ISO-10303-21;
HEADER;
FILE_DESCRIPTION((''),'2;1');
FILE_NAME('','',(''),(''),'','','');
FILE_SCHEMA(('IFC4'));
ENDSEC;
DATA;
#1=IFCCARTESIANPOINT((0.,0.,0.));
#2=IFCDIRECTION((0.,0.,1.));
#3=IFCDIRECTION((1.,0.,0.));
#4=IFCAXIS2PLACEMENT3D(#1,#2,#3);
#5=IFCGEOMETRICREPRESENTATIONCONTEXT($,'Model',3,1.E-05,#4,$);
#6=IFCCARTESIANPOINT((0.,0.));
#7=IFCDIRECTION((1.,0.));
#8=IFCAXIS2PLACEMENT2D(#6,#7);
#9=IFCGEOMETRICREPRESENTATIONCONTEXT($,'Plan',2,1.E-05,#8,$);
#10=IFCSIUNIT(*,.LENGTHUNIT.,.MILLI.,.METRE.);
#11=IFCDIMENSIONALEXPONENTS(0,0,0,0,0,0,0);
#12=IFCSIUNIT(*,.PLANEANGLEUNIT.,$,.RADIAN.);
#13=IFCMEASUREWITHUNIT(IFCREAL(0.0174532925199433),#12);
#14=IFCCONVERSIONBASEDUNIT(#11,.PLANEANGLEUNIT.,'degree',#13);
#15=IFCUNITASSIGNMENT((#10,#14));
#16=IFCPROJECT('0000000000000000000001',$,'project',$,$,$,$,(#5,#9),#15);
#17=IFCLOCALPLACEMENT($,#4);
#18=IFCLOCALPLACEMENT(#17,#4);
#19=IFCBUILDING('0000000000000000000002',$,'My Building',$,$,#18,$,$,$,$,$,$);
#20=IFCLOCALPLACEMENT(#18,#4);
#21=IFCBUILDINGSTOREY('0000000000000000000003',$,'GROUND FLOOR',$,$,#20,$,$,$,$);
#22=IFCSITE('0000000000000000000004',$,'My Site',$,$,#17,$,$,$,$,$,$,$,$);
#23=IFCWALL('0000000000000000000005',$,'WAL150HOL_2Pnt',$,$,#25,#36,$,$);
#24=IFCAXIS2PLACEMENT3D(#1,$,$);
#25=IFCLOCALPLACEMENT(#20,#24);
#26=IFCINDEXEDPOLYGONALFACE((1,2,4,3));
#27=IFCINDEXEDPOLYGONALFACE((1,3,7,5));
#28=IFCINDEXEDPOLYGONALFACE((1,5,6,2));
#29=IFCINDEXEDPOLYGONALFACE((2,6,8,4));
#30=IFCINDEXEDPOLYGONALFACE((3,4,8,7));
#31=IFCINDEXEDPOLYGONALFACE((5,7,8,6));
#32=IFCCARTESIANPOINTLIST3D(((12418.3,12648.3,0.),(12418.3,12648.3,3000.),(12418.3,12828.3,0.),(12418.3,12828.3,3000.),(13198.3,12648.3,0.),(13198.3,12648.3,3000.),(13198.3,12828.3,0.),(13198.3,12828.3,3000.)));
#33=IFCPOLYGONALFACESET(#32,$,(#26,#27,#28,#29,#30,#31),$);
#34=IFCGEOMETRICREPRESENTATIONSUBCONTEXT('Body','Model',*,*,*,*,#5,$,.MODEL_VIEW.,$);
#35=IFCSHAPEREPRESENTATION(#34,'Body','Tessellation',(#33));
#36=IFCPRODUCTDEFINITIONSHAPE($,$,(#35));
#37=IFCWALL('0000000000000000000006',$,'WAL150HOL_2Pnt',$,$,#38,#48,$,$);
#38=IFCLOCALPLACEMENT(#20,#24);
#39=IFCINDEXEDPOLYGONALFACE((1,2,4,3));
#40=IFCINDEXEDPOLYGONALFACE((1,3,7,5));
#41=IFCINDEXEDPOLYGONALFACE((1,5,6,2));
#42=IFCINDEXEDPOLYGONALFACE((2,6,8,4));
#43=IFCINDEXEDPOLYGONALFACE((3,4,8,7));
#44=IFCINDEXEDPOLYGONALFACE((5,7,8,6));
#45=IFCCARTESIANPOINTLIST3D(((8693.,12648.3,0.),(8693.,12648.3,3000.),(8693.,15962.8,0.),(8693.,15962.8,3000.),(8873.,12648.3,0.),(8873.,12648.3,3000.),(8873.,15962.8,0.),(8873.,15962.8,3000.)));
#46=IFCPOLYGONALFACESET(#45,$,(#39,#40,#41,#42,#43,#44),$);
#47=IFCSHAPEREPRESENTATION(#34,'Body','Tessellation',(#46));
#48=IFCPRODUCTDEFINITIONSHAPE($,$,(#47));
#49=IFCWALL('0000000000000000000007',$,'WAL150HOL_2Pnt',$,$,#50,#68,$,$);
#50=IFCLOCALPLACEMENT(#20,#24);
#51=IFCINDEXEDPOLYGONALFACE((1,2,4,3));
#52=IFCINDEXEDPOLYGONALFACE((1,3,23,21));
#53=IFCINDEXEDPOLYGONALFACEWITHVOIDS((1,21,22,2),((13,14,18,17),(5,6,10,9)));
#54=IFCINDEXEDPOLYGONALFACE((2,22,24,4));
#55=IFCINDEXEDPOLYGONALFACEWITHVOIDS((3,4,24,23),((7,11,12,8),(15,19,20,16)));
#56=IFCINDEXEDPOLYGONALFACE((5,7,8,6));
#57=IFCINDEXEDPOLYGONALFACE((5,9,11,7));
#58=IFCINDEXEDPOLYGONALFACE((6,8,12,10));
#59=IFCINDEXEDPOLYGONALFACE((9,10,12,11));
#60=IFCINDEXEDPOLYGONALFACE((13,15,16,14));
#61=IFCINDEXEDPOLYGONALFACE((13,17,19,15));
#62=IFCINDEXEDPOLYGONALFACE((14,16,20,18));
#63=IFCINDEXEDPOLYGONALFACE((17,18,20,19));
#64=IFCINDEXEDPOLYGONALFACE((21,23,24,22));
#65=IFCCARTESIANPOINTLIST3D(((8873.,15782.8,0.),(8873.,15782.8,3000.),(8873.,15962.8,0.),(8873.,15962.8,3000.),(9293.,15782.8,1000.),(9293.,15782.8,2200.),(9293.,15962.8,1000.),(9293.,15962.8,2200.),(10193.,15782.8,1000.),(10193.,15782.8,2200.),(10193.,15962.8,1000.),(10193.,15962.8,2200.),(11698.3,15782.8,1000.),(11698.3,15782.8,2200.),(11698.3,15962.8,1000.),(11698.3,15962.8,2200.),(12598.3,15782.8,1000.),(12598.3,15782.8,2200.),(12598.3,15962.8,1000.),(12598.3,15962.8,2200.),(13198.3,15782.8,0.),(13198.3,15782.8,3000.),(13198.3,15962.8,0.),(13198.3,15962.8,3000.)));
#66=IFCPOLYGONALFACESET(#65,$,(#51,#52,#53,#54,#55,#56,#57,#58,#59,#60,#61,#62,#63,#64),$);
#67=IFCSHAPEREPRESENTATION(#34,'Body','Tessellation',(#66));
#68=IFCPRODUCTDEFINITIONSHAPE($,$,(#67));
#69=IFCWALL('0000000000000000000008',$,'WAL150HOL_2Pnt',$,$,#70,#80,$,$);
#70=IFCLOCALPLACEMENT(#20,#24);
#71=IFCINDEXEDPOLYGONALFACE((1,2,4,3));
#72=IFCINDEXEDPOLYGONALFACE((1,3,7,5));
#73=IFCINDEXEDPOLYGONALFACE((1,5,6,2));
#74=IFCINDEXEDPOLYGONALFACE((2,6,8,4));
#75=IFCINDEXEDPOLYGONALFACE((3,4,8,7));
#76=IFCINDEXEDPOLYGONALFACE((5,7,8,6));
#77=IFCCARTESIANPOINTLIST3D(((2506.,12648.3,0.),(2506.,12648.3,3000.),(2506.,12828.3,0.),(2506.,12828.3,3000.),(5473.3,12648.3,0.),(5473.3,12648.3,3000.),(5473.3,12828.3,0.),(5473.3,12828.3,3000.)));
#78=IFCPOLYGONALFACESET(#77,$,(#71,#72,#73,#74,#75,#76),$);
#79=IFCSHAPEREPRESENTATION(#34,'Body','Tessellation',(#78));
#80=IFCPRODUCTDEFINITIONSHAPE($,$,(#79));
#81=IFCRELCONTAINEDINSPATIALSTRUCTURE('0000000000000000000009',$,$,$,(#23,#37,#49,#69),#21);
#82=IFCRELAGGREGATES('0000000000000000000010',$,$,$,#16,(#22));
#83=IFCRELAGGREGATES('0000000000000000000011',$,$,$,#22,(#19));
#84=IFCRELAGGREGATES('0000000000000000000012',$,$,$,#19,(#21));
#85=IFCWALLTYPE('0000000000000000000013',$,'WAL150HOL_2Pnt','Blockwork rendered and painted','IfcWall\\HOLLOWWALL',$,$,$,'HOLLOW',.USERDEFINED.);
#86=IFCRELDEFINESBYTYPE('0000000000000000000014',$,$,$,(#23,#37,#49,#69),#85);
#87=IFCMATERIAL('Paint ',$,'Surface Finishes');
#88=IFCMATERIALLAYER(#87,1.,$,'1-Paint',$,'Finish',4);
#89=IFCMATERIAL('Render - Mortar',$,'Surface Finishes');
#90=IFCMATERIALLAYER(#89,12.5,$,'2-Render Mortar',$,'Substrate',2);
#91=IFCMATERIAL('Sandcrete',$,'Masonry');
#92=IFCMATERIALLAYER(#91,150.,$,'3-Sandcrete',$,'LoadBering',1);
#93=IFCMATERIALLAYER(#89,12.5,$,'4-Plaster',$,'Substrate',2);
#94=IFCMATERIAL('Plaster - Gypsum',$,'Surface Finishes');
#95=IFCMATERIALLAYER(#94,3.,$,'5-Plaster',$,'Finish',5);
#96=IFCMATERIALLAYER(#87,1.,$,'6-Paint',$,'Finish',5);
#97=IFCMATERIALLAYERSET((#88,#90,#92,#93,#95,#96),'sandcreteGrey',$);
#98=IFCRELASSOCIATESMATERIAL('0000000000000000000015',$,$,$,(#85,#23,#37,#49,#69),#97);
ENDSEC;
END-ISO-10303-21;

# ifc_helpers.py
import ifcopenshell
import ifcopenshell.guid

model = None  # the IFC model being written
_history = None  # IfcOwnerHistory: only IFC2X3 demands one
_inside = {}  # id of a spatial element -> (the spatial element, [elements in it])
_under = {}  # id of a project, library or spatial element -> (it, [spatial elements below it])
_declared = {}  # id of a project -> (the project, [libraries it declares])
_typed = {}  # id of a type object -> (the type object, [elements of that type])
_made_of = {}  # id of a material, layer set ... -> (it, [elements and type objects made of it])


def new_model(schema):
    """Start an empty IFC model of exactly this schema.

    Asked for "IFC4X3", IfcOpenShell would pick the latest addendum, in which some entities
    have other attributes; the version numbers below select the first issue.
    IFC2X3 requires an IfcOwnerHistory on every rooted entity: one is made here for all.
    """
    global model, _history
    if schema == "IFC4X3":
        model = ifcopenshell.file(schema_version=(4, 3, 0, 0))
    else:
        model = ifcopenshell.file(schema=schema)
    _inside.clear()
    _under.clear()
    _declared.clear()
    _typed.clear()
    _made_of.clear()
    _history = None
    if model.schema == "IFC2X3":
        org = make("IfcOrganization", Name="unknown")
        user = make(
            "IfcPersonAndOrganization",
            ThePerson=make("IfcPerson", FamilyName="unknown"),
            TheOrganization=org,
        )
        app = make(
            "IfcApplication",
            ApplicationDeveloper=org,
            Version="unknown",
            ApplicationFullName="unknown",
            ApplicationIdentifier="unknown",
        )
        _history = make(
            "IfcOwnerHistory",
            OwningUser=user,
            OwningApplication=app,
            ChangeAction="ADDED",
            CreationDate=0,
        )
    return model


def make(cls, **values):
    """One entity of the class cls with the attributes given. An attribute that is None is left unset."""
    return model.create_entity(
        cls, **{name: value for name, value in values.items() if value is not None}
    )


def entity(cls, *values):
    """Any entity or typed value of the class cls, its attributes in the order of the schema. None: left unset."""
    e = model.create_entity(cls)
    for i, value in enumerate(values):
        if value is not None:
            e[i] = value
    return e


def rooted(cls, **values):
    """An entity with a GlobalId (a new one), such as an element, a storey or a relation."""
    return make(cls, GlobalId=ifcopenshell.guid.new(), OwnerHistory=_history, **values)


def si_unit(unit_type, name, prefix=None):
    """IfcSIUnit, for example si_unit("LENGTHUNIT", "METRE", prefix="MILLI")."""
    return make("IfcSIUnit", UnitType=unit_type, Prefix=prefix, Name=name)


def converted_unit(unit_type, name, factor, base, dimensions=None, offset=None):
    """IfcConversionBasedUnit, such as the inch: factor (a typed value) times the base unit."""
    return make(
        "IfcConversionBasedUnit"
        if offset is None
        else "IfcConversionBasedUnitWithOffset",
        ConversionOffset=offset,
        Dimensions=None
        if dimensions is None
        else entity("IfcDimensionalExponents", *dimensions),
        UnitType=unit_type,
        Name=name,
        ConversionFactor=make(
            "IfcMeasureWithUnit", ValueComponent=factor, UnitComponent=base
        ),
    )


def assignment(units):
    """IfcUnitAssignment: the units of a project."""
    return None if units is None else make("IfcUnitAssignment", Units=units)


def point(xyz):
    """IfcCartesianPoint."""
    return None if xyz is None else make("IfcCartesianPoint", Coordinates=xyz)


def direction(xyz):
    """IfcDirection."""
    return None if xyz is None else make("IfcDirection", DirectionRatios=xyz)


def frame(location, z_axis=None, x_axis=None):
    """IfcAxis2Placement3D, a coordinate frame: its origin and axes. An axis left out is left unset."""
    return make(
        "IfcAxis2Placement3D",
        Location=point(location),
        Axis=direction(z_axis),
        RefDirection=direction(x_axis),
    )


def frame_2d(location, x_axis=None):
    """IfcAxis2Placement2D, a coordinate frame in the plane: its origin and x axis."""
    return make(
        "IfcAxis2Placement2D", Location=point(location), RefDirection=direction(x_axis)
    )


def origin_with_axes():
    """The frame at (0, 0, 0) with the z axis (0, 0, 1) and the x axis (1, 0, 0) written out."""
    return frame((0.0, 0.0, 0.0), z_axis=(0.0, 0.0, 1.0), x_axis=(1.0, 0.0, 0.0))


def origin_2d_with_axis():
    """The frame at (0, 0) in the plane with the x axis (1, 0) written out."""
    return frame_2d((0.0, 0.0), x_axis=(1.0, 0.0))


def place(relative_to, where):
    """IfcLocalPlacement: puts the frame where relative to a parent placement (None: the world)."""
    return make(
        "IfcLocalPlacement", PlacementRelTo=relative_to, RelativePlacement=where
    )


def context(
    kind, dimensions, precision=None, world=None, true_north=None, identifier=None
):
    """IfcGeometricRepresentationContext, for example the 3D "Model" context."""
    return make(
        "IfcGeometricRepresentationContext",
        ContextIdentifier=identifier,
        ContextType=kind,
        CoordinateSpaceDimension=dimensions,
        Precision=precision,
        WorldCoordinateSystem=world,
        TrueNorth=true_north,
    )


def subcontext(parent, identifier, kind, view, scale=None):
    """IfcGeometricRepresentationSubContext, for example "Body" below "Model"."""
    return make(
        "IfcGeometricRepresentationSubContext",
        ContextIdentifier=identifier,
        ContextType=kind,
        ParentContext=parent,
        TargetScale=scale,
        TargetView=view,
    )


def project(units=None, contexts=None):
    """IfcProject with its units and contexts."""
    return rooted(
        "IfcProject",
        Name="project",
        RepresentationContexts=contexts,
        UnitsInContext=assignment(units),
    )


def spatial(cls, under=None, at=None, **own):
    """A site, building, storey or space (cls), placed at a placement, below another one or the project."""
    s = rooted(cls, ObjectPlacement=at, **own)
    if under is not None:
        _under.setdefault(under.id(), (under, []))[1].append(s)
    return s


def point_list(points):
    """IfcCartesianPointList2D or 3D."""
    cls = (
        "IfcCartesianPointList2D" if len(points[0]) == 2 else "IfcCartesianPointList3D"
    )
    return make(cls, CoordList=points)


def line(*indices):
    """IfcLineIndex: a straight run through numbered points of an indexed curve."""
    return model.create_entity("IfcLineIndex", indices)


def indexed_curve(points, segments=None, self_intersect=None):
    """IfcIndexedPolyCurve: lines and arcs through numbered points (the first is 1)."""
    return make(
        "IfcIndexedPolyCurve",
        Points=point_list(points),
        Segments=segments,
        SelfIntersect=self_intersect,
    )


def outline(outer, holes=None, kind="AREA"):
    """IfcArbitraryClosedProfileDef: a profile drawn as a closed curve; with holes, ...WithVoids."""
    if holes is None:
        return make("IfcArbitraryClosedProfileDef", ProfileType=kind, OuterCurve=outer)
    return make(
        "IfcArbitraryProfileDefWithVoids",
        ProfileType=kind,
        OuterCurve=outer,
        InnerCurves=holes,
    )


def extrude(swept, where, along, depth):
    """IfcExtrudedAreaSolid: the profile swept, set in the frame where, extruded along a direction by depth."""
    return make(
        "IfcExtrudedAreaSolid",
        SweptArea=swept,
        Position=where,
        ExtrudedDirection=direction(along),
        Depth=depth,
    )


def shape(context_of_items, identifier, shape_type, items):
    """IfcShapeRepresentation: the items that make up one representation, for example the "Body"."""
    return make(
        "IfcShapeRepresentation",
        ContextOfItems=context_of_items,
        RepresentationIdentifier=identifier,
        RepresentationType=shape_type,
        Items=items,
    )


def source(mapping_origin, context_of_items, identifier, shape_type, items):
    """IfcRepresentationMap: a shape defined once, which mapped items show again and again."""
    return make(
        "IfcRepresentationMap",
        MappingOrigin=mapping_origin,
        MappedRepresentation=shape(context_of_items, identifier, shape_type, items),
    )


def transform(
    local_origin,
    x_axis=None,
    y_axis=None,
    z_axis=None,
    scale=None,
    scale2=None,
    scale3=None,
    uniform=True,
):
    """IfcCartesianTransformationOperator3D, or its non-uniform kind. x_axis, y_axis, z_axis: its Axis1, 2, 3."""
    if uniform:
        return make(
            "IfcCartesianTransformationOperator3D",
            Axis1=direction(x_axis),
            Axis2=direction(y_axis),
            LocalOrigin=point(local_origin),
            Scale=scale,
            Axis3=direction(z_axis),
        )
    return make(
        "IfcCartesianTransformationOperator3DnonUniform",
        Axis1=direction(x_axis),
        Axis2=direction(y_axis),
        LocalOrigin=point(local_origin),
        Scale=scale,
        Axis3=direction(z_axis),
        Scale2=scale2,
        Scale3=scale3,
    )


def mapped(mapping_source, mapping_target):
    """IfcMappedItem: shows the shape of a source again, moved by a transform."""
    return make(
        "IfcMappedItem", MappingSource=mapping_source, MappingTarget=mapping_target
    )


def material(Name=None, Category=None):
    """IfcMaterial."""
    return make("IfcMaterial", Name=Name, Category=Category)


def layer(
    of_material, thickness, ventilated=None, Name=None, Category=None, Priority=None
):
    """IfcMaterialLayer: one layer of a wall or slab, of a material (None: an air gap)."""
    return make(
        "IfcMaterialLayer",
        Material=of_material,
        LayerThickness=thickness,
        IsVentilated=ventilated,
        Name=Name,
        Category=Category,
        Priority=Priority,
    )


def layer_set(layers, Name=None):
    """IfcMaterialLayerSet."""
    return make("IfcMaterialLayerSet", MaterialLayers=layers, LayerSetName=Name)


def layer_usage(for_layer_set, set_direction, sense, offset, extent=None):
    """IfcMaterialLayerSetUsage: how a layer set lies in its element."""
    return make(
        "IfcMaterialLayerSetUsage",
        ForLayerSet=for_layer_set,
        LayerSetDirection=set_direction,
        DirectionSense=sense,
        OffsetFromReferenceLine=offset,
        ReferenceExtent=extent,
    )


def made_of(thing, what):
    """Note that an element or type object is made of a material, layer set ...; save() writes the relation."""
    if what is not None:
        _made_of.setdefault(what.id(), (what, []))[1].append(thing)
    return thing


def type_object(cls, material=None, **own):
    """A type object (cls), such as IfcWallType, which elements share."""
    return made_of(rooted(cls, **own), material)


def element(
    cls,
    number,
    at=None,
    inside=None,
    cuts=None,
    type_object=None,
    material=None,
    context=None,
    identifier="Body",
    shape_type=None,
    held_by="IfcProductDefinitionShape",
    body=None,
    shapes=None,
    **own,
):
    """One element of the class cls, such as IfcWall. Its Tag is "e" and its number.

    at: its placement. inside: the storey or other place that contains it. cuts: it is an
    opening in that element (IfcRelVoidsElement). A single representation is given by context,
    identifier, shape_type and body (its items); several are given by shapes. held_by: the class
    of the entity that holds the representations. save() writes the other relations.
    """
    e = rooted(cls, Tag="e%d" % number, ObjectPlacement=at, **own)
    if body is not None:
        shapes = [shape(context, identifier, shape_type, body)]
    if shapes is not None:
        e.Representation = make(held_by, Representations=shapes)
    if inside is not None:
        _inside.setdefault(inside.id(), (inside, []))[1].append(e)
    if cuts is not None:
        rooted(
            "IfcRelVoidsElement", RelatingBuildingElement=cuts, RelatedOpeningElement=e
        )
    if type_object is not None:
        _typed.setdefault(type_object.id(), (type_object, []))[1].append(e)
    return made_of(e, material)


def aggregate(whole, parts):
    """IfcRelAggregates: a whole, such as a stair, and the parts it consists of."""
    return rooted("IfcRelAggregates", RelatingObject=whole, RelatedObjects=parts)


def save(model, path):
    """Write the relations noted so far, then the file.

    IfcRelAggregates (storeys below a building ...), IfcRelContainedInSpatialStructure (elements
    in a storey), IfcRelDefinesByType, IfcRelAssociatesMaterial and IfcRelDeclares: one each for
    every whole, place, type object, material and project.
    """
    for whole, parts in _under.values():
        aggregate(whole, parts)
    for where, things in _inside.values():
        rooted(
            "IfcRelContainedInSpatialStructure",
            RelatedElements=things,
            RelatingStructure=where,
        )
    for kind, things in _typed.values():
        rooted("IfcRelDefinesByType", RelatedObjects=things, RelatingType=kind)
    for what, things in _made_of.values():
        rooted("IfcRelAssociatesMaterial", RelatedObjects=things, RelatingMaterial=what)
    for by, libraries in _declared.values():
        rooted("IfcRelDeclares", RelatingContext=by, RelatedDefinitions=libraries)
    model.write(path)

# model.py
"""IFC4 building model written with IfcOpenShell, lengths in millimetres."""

from ifc_helpers import new_model, entity, si_unit, converted_unit, frame, origin_with_axes, origin_2d_with_axis, place, context, subcontext, project, spatial, line, indexed_curve, outline, extrude, source, transform, mapped, material, layer, layer_set, layer_usage, type_object, element, save


model = new_model("IFC4")

# Units and contexts
model_context = context("Model", 3, precision=1e-05, world=origin_with_axes())
plan_context = context("Plan", 2, precision=1e-05, world=origin_2d_with_axis())
body_context_1 = subcontext(model_context, "Body", "Model", "MODEL_VIEW")
ifc_project = project(units=[si_unit("LENGTHUNIT", "METRE", prefix="MILLI"), converted_unit("PLANEANGLEUNIT", "degree", entity("IfcReal", 0.0174532925199433), si_unit("PLANEANGLEUNIT", "RADIAN"), dimensions=[0, 0, 0, 0, 0, 0, 0])], contexts=[model_context, plan_context])

# Site, building, storey
site_placement = place(None, origin_with_axes())
site = spatial("IfcSite", under=ifc_project, at=site_placement, Name="My Site")
building_placement = place(site_placement, origin_with_axes())
building = spatial("IfcBuilding", under=site, at=building_placement, Name="My Building")
storey_placement = place(building_placement, origin_with_axes())
storey = spatial("IfcBuildingStorey", under=building, at=storey_placement, Name="GROUND FLOOR")

# Walls
ifc_material_1 = material(Name="Paint ", Category="Surface Finishes")
ifc_layer_1 = layer(ifc_material_1, 1.0, Name="1-Paint", Category="Finish", Priority=4)
ifc_material_2 = material(Name="Render - Mortar", Category="Surface Finishes")
ifc_layer_2 = layer(ifc_material_2, 12.5, Name="2-Render Mortar", Category="Substrate", Priority=2)
ifc_material_3 = material(Name="Sandcrete", Category="Masonry")
ifc_layer_3 = layer(ifc_material_3, 150.0, Name="3-Sandcrete", Category="LoadBering", Priority=1)
ifc_layer_4 = layer(ifc_material_2, 12.5, Name="4-Plaster", Category="Substrate", Priority=2)
ifc_material_4 = material(Name="Plaster - Gypsum", Category="Surface Finishes")
ifc_layer_5 = layer(ifc_material_4, 3.0, Name="5-Plaster", Category="Finish", Priority=5)
ifc_layer_6 = layer(ifc_material_1, 1.0, Name="6-Paint", Category="Finish", Priority=5)
ifc_layer_set_1 = layer_set([ifc_layer_1, ifc_layer_2, ifc_layer_3, ifc_layer_4, ifc_layer_5, ifc_layer_6], Name="sandcreteGrey")
ifc_layer_usage_1 = layer_usage(ifc_layer_set_1, "AXIS2", "POSITIVE", 0.0)
wall_type_1 = type_object("IfcWallType", Name="WAL150HOL_2Pnt", Description="Blockwork rendered and painted", ApplicableOccurrence="IfcWall\\HOLLOWWALL", ElementType="HOLLOW", PredefinedType="USERDEFINED", material=ifc_layer_set_1)
wall_1_placement = place(storey_placement, frame((13198.3, 12828.3, 0.0), z_axis=(0.0, 0.0, 1.0), x_axis=(-1.0, 0.000001, 0.0)))
element("IfcWall", 1, at=wall_1_placement, inside=storey, type_object=wall_type_1, material=ifc_layer_usage_1, Name="WAL150HOL_2Pnt", context=body_context_1, shape_type="SweptSolid", body=[
    extrude(outline(indexed_curve([(0.0, 0.0), (0.0, 180.0), (780.0, 180.0), (780.0, 0.0), (0.0, 0.0)], self_intersect=False)), origin_with_axes(), (0.0, 0.0, 1.0), 3000.0),
])
ifc_layer_usage_2 = layer_usage(ifc_layer_set_1, "AXIS2", "POSITIVE", 0.0)
wall_2_placement = place(storey_placement, frame((8693.0, 15962.8, 0.0), z_axis=(0.0, 0.0, 1.0), x_axis=(-0.000001, -1.0, 0.0)))
element("IfcWall", 2, at=wall_2_placement, inside=storey, type_object=wall_type_1, material=ifc_layer_usage_2, Name="WAL150HOL_2Pnt", context=body_context_1, shape_type="SweptSolid", body=[
    extrude(outline(indexed_curve([(0.0, 0.0), (0.0, 180.0), (3314.5, 180.0), (3314.5, 0.0), (0.0, 0.0)], self_intersect=False)), origin_with_axes(), (0.0, 0.0, 1.0), 3000.0),
])

# Wall, openings
ifc_layer_usage_3 = layer_usage(ifc_layer_set_1, "AXIS2", "POSITIVE", 0.0)
wall_3_placement = place(storey_placement, frame((13198.3, 15962.8, 0.0), z_axis=(0.0, 0.0, 1.0), x_axis=(-1.0, 0.000001, 0.0)))
wall_3 = element("IfcWall", 3, at=wall_3_placement, inside=storey, type_object=wall_type_1, material=ifc_layer_usage_3, Name="WAL150HOL_2Pnt", context=body_context_1, shape_type="SweptSolid", body=[
    extrude(outline(indexed_curve([(0.0, 0.0), (0.0, 180.0), (4325.3, 180.0), (4325.3, 0.0), (0.0, 0.0)], self_intersect=False)), origin_with_axes(), (0.0, 0.0, 1.0), 3000.0),
])
shared_shape_1 = source(origin_with_axes(), body_context_1, "Body", "SweptSolid", [
    extrude(outline(indexed_curve([(0.0, 0.0), (900.0, 0.0), (900.0, 1200.0), (0.0, 1200.0)], segments=[line(1, 2, 3, 4, 1)])), frame((0.0, -600.0, 0.0), z_axis=(0.0, -1.0, 0.0), x_axis=(1.0, 0.0, 0.0)), (0.0, 0.0, -1.0), 1200.0),
])
opening_1_placement = place(wall_3_placement, frame((3005.3, 0.0, 1000.0), z_axis=(0.0, 0.0, 1.0), x_axis=(1.0, 0.0, 0.0)))
element("IfcOpeningElement", 4, at=opening_1_placement, cuts=wall_3, PredefinedType="OPENING", context=body_context_1, shape_type="MappedRepresentation", body=[
    mapped(shared_shape_1, transform((0.0, 0.0, 0.0), x_axis=(1.0, 0.0, 0.0), y_axis=(0.0, 1.0, 0.0), z_axis=(0.0, 0.0, 1.0), scale=1.0)),
])
opening_2_placement = place(wall_3_placement, frame((600.0, 0.0, 1000.0), z_axis=(0.0, 0.0, 1.0), x_axis=(1.0, 0.0, 0.0)))
element("IfcOpeningElement", 5, at=opening_2_placement, cuts=wall_3, PredefinedType="OPENING", context=body_context_1, shape_type="MappedRepresentation", body=[
    mapped(shared_shape_1, transform((0.0, 0.0, 0.0), x_axis=(1.0, 0.0, 0.0), y_axis=(0.0, 1.0, 0.0), z_axis=(0.0, 0.0, 1.0), scale=1.0)),
])

# Wall
ifc_layer_usage_4 = layer_usage(ifc_layer_set_1, "AXIS2", "POSITIVE", 0.0)
wall_4_placement = place(storey_placement, frame((5473.3, 12828.3, 0.0), z_axis=(0.0, 0.0, 1.0), x_axis=(-1.0, 0.0, 0.0)))
element("IfcWall", 6, at=wall_4_placement, inside=storey, type_object=wall_type_1, material=ifc_layer_usage_4, Name="WAL150HOL_2Pnt", context=body_context_1, shape_type="SweptSolid", body=[
    extrude(outline(indexed_curve([(0.0, 0.0), (0.0, 180.0), (2967.3, 180.0), (2967.3, 0.0), (0.0, 0.0)], self_intersect=False)), origin_with_axes(), (0.0, 0.0, 1.0), 3000.0),
])

save(model, "model.ifc")
